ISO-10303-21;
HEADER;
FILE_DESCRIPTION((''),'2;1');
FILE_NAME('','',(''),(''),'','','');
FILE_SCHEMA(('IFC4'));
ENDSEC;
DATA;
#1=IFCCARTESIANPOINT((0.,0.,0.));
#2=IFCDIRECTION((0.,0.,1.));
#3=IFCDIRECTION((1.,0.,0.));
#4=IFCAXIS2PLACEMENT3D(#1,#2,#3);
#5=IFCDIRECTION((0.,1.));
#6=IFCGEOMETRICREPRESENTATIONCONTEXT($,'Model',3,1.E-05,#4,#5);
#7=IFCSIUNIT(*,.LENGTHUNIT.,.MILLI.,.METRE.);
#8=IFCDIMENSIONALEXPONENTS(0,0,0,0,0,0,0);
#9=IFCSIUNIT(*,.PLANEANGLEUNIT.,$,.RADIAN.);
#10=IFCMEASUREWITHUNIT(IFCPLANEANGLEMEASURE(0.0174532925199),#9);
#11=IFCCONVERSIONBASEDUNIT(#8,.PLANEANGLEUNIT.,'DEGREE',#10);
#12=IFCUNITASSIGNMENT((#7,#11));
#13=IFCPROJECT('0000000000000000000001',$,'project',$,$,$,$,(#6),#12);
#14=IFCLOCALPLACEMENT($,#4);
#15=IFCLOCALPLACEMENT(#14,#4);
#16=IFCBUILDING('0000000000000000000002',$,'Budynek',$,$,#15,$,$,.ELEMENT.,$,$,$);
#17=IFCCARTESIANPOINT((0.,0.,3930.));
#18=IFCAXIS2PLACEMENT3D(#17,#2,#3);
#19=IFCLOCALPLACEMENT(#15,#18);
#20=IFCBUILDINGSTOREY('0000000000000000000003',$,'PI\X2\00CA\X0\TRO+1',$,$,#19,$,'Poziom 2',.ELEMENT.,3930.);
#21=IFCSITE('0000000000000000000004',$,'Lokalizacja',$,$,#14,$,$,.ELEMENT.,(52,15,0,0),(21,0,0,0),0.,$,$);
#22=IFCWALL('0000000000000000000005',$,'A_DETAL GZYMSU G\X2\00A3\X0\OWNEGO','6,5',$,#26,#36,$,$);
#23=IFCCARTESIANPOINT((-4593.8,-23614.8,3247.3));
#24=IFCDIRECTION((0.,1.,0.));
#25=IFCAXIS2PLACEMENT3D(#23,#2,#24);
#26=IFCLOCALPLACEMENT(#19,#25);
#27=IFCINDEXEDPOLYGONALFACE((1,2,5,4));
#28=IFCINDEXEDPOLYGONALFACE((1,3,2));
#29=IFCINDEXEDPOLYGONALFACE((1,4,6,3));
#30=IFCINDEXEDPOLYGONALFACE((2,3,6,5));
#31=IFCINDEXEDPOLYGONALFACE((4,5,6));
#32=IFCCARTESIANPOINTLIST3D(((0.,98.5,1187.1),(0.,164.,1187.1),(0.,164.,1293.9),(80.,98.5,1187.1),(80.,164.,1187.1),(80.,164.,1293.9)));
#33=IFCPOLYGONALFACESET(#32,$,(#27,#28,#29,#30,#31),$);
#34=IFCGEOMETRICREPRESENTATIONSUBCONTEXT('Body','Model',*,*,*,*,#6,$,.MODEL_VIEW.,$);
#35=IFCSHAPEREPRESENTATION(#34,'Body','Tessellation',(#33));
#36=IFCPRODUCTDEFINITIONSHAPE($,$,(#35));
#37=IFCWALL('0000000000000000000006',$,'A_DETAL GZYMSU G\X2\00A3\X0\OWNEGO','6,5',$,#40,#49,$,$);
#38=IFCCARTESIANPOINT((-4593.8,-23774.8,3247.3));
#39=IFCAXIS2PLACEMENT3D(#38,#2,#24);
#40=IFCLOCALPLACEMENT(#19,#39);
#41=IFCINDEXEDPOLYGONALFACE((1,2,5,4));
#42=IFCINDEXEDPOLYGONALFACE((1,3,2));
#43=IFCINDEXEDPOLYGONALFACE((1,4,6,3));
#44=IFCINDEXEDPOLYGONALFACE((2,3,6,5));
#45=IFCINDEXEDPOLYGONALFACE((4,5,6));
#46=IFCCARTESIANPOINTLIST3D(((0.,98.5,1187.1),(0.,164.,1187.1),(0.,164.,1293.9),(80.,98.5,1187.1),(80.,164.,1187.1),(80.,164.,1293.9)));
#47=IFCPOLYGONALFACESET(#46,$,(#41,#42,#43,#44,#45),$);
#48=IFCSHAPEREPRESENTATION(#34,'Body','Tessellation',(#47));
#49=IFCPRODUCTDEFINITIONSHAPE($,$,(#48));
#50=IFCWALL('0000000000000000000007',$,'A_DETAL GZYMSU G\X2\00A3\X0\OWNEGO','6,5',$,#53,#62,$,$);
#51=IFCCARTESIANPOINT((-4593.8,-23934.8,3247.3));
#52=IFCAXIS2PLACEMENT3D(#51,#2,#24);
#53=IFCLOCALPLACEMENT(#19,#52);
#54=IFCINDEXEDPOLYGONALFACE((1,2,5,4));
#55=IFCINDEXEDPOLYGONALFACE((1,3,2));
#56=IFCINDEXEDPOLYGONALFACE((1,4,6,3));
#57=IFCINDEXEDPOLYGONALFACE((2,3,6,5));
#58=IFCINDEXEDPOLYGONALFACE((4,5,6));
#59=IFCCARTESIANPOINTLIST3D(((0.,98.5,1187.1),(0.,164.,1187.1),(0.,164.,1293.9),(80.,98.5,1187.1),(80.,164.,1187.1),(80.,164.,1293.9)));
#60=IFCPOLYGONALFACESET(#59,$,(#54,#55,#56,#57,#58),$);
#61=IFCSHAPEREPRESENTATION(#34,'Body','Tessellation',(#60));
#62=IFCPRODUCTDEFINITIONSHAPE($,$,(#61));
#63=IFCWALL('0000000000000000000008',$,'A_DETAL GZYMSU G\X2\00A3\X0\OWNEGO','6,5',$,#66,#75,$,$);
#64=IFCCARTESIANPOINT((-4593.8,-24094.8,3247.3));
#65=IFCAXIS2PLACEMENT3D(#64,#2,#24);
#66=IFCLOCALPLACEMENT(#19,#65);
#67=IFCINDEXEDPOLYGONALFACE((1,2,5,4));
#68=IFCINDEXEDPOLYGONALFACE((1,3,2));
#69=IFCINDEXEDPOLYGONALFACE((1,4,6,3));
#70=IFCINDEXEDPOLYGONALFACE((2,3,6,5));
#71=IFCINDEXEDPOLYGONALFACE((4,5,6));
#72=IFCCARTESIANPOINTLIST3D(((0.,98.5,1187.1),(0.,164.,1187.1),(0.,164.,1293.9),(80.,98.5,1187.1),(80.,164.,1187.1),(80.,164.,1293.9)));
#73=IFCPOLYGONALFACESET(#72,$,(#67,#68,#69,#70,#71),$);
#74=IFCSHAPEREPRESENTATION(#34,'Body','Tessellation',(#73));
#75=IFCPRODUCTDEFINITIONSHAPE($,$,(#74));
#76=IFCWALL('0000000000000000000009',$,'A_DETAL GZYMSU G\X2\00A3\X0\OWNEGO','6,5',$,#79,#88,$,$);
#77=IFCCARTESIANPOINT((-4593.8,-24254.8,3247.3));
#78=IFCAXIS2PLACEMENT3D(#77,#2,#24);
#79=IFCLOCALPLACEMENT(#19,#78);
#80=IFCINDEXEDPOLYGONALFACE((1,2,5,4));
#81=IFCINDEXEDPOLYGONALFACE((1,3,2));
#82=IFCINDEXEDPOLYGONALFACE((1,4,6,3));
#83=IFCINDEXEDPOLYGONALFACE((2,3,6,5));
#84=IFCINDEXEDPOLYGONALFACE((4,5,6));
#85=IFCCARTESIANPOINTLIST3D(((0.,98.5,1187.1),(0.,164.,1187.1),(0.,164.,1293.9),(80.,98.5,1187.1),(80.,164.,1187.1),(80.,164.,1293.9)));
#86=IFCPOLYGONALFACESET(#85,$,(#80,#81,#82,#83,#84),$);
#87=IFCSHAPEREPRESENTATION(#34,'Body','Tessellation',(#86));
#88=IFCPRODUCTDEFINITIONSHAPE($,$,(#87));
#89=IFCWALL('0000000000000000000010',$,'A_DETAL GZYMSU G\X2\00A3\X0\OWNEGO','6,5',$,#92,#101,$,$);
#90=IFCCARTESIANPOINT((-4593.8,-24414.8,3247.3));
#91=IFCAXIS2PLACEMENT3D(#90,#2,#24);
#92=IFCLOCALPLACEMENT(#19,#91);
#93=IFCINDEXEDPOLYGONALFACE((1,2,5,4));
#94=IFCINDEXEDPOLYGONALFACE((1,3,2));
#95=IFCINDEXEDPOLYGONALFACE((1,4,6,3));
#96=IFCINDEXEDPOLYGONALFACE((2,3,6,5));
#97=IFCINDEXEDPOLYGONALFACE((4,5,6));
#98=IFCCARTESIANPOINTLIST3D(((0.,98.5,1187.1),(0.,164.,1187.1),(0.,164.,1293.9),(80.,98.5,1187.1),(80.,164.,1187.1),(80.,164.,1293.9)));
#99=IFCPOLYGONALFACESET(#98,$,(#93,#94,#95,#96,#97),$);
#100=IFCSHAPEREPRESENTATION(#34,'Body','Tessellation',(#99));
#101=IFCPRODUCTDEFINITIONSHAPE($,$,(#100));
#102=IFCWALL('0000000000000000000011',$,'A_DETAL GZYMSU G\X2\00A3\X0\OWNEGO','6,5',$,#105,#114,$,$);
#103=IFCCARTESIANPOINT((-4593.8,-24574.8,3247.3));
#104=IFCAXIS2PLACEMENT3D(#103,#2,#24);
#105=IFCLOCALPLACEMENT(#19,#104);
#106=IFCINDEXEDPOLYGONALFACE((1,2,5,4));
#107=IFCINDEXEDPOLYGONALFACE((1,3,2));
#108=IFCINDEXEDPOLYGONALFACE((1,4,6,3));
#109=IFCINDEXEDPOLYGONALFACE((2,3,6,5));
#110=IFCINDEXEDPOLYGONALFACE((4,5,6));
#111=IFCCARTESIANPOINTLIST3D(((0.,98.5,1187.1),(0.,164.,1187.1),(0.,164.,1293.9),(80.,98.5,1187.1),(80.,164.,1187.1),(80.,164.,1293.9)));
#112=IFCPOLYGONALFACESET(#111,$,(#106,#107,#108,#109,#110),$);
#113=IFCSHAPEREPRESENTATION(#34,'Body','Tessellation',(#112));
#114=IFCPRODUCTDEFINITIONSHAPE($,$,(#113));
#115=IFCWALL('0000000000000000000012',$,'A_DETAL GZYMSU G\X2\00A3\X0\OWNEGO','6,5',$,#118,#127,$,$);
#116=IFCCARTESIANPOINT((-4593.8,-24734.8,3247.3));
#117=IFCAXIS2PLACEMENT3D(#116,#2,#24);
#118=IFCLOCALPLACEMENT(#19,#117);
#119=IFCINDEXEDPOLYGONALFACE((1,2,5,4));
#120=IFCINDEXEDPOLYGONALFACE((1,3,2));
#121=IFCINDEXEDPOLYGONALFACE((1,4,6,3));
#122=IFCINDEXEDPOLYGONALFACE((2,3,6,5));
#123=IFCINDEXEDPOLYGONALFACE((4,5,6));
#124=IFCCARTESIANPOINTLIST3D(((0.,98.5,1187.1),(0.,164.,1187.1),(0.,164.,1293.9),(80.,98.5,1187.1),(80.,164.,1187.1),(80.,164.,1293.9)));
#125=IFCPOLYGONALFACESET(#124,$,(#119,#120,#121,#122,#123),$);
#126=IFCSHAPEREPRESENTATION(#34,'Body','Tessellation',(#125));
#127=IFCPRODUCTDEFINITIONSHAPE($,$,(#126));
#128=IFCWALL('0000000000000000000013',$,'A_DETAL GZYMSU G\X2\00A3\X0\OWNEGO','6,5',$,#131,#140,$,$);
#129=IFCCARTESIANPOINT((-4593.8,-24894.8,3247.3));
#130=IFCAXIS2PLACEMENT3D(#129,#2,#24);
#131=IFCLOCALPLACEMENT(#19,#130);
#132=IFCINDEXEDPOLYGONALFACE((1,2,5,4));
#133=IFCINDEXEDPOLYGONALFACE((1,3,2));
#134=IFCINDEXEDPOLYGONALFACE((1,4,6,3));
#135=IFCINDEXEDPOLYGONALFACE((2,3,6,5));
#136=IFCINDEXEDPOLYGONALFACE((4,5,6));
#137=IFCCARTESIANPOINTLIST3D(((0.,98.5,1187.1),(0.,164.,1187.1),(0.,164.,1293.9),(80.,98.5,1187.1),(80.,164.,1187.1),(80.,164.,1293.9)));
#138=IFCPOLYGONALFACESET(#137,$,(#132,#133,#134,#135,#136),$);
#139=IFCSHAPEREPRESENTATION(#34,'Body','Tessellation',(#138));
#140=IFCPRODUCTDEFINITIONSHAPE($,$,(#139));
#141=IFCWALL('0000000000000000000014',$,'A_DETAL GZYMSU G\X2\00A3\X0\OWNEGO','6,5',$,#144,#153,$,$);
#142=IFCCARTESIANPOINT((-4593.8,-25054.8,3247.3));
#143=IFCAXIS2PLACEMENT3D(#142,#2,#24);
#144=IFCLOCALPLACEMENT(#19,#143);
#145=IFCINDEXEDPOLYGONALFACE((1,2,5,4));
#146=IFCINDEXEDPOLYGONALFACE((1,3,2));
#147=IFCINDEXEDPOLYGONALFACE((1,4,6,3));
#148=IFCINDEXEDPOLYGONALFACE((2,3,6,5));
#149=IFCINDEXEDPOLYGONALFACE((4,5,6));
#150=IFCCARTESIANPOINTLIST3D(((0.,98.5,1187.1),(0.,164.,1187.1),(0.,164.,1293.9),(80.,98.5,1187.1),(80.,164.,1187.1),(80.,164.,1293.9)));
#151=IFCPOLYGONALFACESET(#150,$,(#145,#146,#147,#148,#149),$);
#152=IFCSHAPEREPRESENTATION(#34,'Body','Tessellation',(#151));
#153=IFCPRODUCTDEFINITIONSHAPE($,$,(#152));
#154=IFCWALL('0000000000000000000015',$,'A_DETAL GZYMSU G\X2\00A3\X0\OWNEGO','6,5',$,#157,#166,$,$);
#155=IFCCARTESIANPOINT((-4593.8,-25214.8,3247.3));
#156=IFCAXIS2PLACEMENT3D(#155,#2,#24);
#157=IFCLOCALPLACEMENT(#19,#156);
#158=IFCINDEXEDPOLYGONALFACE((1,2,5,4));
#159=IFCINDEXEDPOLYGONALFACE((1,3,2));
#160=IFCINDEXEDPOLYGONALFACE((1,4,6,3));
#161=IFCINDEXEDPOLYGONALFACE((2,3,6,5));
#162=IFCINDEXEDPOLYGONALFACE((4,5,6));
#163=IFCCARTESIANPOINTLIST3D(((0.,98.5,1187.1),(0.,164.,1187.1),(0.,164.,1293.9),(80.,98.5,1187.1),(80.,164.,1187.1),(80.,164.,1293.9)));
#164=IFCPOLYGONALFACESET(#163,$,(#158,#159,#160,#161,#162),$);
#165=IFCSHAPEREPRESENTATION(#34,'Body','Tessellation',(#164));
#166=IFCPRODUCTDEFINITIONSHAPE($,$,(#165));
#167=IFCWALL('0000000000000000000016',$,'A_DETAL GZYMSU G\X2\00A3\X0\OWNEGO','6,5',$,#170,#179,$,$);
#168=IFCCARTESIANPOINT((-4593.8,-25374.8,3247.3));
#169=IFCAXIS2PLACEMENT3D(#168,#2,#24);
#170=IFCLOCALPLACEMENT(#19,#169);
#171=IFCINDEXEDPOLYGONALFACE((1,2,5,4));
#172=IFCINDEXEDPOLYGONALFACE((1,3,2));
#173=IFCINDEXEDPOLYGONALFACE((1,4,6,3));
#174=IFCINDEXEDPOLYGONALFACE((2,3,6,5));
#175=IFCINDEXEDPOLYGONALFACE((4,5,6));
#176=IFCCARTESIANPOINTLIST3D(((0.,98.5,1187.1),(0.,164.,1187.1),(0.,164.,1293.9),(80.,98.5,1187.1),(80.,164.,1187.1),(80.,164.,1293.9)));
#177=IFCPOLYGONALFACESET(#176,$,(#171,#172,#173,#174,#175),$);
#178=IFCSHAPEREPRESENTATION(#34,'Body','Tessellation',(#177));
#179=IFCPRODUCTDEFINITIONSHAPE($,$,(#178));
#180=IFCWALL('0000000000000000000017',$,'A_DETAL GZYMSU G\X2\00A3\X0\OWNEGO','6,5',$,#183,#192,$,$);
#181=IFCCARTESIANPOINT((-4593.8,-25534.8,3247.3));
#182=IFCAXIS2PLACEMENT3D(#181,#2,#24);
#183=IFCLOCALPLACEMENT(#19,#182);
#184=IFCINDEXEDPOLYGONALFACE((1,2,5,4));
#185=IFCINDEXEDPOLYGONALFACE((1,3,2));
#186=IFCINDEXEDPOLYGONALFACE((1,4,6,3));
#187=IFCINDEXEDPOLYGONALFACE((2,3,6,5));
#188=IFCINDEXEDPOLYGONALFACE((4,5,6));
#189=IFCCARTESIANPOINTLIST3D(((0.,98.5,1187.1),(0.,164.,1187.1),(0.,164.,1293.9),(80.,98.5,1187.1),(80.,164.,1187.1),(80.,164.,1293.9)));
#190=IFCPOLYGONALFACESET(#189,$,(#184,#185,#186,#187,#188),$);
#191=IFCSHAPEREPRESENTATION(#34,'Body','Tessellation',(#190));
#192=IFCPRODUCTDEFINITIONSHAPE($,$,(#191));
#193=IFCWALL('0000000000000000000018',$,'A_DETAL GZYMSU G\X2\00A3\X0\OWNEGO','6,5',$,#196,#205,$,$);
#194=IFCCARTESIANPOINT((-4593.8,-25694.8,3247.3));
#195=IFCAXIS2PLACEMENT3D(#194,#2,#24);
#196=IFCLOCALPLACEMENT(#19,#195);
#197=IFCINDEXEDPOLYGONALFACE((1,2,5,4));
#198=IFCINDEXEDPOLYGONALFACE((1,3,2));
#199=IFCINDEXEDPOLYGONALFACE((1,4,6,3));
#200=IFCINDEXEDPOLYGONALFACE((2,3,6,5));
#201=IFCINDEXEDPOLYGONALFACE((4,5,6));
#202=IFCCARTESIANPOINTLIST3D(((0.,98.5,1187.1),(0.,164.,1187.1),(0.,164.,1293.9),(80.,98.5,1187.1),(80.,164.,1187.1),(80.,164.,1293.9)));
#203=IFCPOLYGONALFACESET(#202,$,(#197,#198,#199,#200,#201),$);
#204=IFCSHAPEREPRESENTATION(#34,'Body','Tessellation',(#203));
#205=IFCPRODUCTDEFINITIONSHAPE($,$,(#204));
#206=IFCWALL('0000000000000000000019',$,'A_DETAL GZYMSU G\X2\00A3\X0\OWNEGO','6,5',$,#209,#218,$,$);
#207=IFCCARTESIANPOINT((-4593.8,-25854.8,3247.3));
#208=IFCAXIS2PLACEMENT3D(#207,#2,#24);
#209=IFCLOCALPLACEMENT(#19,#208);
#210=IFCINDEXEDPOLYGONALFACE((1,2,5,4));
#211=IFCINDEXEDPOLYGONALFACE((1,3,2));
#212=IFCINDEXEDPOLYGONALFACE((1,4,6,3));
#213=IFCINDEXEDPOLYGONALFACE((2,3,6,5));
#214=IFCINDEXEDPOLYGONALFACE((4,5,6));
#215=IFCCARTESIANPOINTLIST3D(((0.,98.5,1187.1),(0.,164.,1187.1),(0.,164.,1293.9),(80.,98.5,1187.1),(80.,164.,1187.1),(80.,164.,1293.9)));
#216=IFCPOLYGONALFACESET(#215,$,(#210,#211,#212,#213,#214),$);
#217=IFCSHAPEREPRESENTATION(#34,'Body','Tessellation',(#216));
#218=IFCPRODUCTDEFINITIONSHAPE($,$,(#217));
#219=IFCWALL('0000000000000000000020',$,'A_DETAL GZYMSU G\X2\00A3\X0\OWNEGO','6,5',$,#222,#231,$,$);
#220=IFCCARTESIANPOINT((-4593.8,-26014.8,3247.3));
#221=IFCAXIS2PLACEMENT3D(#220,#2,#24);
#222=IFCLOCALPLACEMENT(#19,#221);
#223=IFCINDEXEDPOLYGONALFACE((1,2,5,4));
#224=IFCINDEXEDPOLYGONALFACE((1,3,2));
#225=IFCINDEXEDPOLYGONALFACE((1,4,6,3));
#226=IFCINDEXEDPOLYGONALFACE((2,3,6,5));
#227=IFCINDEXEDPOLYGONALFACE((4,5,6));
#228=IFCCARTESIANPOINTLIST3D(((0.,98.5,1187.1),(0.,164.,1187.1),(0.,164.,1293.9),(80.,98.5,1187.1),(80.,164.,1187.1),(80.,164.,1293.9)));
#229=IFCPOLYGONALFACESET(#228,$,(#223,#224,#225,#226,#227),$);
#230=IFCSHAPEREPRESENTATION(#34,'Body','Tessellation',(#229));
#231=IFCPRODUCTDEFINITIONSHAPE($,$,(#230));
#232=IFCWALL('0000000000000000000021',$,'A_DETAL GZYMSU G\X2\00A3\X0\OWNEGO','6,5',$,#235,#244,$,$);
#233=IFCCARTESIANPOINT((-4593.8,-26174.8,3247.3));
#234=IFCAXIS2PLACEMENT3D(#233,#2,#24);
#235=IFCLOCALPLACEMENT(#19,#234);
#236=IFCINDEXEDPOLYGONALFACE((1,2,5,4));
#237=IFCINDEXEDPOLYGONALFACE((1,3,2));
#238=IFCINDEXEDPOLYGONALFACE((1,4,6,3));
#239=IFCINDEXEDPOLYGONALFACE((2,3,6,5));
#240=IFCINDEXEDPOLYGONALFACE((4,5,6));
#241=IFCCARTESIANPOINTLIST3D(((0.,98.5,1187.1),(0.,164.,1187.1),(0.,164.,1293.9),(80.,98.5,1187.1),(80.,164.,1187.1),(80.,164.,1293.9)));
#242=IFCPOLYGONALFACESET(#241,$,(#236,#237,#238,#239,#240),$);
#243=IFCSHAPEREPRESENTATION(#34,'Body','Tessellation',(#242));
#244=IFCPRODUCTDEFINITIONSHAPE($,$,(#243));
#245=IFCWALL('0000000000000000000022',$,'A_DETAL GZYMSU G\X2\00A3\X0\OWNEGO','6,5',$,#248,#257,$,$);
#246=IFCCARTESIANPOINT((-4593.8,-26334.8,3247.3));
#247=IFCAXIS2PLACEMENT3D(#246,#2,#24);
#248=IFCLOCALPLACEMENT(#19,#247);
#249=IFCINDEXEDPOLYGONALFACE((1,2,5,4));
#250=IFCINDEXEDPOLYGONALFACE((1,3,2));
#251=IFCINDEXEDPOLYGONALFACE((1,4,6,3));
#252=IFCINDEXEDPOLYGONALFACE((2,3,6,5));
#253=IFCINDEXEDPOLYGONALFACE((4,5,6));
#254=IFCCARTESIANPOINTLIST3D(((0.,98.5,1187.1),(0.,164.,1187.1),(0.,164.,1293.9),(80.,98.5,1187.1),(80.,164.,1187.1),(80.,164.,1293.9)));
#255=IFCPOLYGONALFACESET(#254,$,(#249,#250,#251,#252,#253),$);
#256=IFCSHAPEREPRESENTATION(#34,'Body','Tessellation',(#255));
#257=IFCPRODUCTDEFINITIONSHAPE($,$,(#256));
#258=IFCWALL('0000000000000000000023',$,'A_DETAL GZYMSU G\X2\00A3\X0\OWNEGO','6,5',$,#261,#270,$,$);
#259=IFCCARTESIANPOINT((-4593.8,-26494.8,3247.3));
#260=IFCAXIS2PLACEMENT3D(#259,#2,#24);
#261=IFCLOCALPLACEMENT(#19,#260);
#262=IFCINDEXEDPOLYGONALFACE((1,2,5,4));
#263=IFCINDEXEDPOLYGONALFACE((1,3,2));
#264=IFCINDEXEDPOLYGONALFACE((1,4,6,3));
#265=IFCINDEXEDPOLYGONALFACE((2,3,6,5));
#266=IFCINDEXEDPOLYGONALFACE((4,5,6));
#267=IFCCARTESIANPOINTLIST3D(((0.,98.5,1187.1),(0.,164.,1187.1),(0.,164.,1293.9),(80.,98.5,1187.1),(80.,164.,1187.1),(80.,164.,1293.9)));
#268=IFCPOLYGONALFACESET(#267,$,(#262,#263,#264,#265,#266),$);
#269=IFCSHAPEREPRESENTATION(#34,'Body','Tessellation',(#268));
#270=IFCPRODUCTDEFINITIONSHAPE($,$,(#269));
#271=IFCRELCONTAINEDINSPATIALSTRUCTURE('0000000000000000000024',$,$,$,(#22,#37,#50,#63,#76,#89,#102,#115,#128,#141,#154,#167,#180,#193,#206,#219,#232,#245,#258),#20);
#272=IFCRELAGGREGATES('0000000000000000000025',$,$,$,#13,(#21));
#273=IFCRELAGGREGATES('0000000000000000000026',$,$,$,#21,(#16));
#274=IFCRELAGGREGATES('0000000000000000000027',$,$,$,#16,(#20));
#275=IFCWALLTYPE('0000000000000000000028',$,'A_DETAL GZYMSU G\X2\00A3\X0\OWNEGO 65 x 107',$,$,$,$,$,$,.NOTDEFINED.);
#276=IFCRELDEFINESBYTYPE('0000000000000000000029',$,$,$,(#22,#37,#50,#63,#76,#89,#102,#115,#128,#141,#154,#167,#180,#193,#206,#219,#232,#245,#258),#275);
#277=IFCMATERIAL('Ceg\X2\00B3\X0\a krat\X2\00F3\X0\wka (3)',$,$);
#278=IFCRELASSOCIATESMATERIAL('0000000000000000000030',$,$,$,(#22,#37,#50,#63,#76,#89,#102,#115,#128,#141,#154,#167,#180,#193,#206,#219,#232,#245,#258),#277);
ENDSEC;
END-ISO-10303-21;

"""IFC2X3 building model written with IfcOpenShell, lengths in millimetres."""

from ifc_helpers import new_model, entity, si_unit, converted_unit, direction, frame, origin_with_axes, place, context, subcontext, project, spatial, polyline, outline, extrude, material, type_object, element, save


model = new_model("IFC2X3")

# Units and contexts
model_context = context("Model", 3, precision=1e-05, world=origin_with_axes(), true_north=direction((0.0, 1.0)))
body_context = subcontext(model_context, "Body", "Model", "MODEL_VIEW")
ifc_project = project(units=[si_unit("LENGTHUNIT", "METRE", prefix="MILLI"), converted_unit("PLANEANGLEUNIT", "DEGREE", entity("IfcPlaneAngleMeasure", 0.0174532925199), si_unit("PLANEANGLEUNIT", "RADIAN"), dimensions=[0, 0, 0, 0, 0, 0, 0])], contexts=[model_context])

# Site, building, storey
site_placement = place(None, origin_with_axes())
site = spatial("IfcSite", under=ifc_project, at=site_placement, Name="Lokalizacja", CompositionType="ELEMENT", RefLatitude=(52, 15, 0, 0), RefLongitude=(21, 0, 0, 0), RefElevation=0.0)
building_placement = place(site_placement, origin_with_axes())
building = spatial("IfcBuilding", under=site, at=building_placement, Name="Budynek", CompositionType="ELEMENT")
storey_placement = place(building_placement, frame((0.0, 0.0, 3930.0), z_axis=(0.0, 0.0, 1.0), x_axis=(1.0, 0.0, 0.0)))
storey = spatial("IfcBuildingStorey", under=building, at=storey_placement, Name="PIÊTRO+1", LongName="Poziom 2", CompositionType="ELEMENT", Elevation=3930.0)

# Walls
ifc_material = material(Name="Ceg³a kratówka (3)")
wall_type_1 = type_object("IfcWallType", Name="A_DETAL GZYMSU G£OWNEGO 65 x 107", PredefinedType="NOTDEFINED")
for number, where, z_axis, x_axis, name in (
    (1, (-4593.8, -23614.8, 3247.3), (0.0, 0.0, 1.0), (0.0, 1.0, 0.0), "A_DETAL GZYMSU G£OWNEGO"),
    (2, (-4593.8, -23774.8, 3247.3), (0.0, 0.0, 1.0), (0.0, 1.0, 0.0), "A_DETAL GZYMSU G£OWNEGO"),
    (3, (-4593.8, -23934.8, 3247.3), (0.0, 0.0, 1.0), (0.0, 1.0, 0.0), "A_DETAL GZYMSU G£OWNEGO"),
    (4, (-4593.8, -24094.8, 3247.3), (0.0, 0.0, 1.0), (0.0, 1.0, 0.0), "A_DETAL GZYMSU G£OWNEGO"),
    (5, (-4593.8, -24254.8, 3247.3), (0.0, 0.0, 1.0), (0.0, 1.0, 0.0), "A_DETAL GZYMSU G£OWNEGO"),
    (6, (-4593.8, -24414.8, 3247.3), (0.0, 0.0, 1.0), (0.0, 1.0, 0.0), "A_DETAL GZYMSU G£OWNEGO"),
    (7, (-4593.8, -24574.8, 3247.3), (0.0, 0.0, 1.0), (0.0, 1.0, 0.0), "A_DETAL GZYMSU G£OWNEGO"),
    (8, (-4593.8, -24734.8, 3247.3), (0.0, 0.0, 1.0), (0.0, 1.0, 0.0), "A_DETAL GZYMSU G£OWNEGO"),
    (9, (-4593.8, -24894.8, 3247.3), (0.0, 0.0, 1.0), (0.0, 1.0, 0.0), "A_DETAL GZYMSU G£OWNEGO"),
    (10, (-4593.8, -25054.8, 3247.3), (0.0, 0.0, 1.0), (0.0, 1.0, 0.0), "A_DETAL GZYMSU G£OWNEGO"),
    (11, (-4593.8, -25214.8, 3247.3), (0.0, 0.0, 1.0), (0.0, 1.0, 0.0), "A_DETAL GZYMSU G£OWNEGO"),
    (12, (-4593.8, -25374.8, 3247.3), (0.0, 0.0, 1.0), (0.0, 1.0, 0.0), "A_DETAL GZYMSU G£OWNEGO"),
    (13, (-4593.8, -25534.8, 3247.3), (0.0, 0.0, 1.0), (0.0, 1.0, 0.0), "A_DETAL GZYMSU G£OWNEGO"),
    (14, (-4593.8, -25694.8, 3247.3), (0.0, 0.0, 1.0), (0.0, 1.0, 0.0), "A_DETAL GZYMSU G£OWNEGO"),
    (15, (-4593.8, -25854.8, 3247.3), (0.0, 0.0, 1.0), (0.0, 1.0, 0.0), "A_DETAL GZYMSU G£OWNEGO"),
    (16, (-4593.8, -26014.8, 3247.3), (0.0, 0.0, 1.0), (0.0, 1.0, 0.0), "A_DETAL GZYMSU G£OWNEGO"),
    (17, (-4593.8, -26174.8, 3247.3), (0.0, 0.0, 1.0), (0.0, 1.0, 0.0), "A_DETAL GZYMSU G£OWNEGO"),
    (18, (-4593.8, -26334.8, 3247.3), (0.0, 0.0, 1.0), (0.0, 1.0, 0.0), "A_DETAL GZYMSU G£OWNEGO"),
    (19, (-4593.8, -26494.8, 3247.3), (0.0, 0.0, 1.0), (0.0, 1.0, 0.0), "A_DETAL GZYMSU G£OWNEGO"),
):
    element("IfcWall", number, at=place(storey_placement, frame(where, z_axis=z_axis, x_axis=x_axis)), inside=storey, type_object=wall_type_1, material=ifc_material, Name=name, Description="6,5", context=body_context, shape_type="SweptSolid", body=[
        extrude(outline(polyline([(-164.0, 1293.9), (-164.0, 1187.1), (-98.5, 1187.1), (-164.0, 1293.9)])), frame((0.0, 0.0, 0.0), z_axis=(-1.0, 0.0, 0.0), x_axis=(0.0, -1.0, 0.0)), (0.0, 0.0, -1.0), 80.0),
    ])

save(model, "model.ifc")
